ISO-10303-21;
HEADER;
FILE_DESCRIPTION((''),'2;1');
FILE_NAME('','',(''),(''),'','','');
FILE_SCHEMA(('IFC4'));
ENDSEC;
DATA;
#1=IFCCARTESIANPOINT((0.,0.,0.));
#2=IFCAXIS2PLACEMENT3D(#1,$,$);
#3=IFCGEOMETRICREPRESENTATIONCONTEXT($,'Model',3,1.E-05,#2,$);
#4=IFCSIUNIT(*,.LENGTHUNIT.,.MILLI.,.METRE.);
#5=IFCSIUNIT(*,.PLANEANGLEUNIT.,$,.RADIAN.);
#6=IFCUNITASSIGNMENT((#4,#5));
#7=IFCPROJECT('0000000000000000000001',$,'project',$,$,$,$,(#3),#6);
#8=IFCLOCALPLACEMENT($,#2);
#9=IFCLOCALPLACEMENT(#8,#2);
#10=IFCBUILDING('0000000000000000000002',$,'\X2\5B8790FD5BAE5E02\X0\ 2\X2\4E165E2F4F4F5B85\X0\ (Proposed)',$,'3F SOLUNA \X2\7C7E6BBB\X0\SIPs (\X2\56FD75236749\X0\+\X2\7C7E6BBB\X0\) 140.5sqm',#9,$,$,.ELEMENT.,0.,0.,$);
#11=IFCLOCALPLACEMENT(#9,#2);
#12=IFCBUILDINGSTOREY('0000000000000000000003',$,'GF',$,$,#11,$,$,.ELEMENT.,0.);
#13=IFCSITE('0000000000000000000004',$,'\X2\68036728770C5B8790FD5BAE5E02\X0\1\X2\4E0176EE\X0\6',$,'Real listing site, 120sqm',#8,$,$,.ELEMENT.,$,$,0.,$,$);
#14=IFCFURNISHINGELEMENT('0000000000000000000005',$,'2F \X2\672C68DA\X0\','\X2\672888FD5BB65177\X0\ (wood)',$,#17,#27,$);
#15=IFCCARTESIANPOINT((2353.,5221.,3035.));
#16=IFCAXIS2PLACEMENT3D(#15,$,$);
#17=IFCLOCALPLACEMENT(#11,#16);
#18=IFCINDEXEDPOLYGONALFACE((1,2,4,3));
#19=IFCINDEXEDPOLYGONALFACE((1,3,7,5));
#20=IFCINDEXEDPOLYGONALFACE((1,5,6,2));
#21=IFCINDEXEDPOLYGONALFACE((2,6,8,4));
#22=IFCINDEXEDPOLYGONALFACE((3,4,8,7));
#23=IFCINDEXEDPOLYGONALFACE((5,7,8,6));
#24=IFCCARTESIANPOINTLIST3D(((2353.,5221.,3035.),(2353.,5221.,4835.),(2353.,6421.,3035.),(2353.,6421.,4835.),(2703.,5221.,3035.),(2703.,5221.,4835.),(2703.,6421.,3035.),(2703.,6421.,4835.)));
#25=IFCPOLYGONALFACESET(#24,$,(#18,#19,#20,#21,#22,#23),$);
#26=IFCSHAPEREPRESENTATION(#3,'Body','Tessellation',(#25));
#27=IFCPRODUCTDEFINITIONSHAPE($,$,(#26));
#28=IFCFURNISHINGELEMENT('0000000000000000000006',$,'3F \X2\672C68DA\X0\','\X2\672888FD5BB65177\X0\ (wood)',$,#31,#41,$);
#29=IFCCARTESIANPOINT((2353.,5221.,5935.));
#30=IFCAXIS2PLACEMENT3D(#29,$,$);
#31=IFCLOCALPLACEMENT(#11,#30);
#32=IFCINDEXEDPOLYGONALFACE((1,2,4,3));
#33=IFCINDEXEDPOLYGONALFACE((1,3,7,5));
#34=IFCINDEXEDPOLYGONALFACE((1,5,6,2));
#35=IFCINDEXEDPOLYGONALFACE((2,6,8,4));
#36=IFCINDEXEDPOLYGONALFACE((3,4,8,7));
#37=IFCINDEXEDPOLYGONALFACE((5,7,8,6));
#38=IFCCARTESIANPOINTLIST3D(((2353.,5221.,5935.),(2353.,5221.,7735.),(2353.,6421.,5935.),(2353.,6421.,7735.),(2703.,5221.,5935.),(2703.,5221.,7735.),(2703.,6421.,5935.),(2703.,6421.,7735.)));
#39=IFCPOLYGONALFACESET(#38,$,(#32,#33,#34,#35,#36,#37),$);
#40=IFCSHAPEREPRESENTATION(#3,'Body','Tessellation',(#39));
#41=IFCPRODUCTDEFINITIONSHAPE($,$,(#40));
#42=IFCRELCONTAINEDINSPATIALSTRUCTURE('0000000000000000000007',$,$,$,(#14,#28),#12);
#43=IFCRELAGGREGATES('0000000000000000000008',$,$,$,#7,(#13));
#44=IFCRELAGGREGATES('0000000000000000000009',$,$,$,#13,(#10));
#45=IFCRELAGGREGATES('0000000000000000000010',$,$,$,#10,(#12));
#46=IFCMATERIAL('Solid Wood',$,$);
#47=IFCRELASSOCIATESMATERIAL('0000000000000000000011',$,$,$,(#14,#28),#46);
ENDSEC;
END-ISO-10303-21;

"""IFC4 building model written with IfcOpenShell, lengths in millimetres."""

from ifc_helpers import new_model, si_unit, frame, frame_2d, origin, place, context, project, spatial, rectangle, extrude, material, element, save


model = new_model("IFC4")

# Units and contexts
model_context = context("Model", 3, precision=1e-05, world=origin())
ifc_project = project(units=[si_unit("LENGTHUNIT", "METRE", prefix="MILLI"), si_unit("PLANEANGLEUNIT", "RADIAN")], contexts=[model_context])

# Site, building, storey
site_placement = place(None, origin())
site = spatial("IfcSite", under=ifc_project, at=site_placement, Name="栃木県宇都宮市1丁目6", ObjectType="Real listing site, 120sqm", CompositionType="ELEMENT", RefElevation=0.0)
building_placement = place(site_placement, origin())
building = spatial("IfcBuilding", under=site, at=building_placement, Name="宇都宮市 2世帯住宅 (Proposed)", ObjectType="3F SOLUNA 籾殻SIPs (国産杉+籾殻) 140.5sqm", CompositionType="ELEMENT", ElevationOfRefHeight=0.0, ElevationOfTerrain=0.0)
storey_placement = place(building_placement, origin())
storey = spatial("IfcBuildingStorey", under=building, at=storey_placement, Name="GF", CompositionType="ELEMENT", Elevation=0.0)

# Shared definitions
ifc_material_1 = material(Name="Solid Wood")

# Furnishing elements
furnishing_1_placement = place(storey_placement, frame((2353.0, 5221.0, 3035.0)))
element("IfcFurnishingElement", 1, at=furnishing_1_placement, inside=storey, material=ifc_material_1, Name="2F 本棚", Description="木製家具 (wood)", context=model_context, shape_type="SweptSolid", body=[
    extrude(rectangle(XDim=350.0, YDim=1200.0, at=frame_2d((175.0, 600.0))), frame((2353.0, 5221.0, 3035.0)), (0.0, 0.0, 1.0), 1800.0),
])
furnishing_2_placement = place(storey_placement, frame((2353.0, 5221.0, 5935.0)))
element("IfcFurnishingElement", 2, at=furnishing_2_placement, inside=storey, material=ifc_material_1, Name="3F 本棚", Description="木製家具 (wood)", context=model_context, shape_type="SweptSolid", body=[
    extrude(rectangle(XDim=350.0, YDim=1200.0, at=frame_2d((175.0, 600.0))), frame((2353.0, 5221.0, 5935.0)), (0.0, 0.0, 1.0), 1800.0),
])

save(model, "model.ifc")
